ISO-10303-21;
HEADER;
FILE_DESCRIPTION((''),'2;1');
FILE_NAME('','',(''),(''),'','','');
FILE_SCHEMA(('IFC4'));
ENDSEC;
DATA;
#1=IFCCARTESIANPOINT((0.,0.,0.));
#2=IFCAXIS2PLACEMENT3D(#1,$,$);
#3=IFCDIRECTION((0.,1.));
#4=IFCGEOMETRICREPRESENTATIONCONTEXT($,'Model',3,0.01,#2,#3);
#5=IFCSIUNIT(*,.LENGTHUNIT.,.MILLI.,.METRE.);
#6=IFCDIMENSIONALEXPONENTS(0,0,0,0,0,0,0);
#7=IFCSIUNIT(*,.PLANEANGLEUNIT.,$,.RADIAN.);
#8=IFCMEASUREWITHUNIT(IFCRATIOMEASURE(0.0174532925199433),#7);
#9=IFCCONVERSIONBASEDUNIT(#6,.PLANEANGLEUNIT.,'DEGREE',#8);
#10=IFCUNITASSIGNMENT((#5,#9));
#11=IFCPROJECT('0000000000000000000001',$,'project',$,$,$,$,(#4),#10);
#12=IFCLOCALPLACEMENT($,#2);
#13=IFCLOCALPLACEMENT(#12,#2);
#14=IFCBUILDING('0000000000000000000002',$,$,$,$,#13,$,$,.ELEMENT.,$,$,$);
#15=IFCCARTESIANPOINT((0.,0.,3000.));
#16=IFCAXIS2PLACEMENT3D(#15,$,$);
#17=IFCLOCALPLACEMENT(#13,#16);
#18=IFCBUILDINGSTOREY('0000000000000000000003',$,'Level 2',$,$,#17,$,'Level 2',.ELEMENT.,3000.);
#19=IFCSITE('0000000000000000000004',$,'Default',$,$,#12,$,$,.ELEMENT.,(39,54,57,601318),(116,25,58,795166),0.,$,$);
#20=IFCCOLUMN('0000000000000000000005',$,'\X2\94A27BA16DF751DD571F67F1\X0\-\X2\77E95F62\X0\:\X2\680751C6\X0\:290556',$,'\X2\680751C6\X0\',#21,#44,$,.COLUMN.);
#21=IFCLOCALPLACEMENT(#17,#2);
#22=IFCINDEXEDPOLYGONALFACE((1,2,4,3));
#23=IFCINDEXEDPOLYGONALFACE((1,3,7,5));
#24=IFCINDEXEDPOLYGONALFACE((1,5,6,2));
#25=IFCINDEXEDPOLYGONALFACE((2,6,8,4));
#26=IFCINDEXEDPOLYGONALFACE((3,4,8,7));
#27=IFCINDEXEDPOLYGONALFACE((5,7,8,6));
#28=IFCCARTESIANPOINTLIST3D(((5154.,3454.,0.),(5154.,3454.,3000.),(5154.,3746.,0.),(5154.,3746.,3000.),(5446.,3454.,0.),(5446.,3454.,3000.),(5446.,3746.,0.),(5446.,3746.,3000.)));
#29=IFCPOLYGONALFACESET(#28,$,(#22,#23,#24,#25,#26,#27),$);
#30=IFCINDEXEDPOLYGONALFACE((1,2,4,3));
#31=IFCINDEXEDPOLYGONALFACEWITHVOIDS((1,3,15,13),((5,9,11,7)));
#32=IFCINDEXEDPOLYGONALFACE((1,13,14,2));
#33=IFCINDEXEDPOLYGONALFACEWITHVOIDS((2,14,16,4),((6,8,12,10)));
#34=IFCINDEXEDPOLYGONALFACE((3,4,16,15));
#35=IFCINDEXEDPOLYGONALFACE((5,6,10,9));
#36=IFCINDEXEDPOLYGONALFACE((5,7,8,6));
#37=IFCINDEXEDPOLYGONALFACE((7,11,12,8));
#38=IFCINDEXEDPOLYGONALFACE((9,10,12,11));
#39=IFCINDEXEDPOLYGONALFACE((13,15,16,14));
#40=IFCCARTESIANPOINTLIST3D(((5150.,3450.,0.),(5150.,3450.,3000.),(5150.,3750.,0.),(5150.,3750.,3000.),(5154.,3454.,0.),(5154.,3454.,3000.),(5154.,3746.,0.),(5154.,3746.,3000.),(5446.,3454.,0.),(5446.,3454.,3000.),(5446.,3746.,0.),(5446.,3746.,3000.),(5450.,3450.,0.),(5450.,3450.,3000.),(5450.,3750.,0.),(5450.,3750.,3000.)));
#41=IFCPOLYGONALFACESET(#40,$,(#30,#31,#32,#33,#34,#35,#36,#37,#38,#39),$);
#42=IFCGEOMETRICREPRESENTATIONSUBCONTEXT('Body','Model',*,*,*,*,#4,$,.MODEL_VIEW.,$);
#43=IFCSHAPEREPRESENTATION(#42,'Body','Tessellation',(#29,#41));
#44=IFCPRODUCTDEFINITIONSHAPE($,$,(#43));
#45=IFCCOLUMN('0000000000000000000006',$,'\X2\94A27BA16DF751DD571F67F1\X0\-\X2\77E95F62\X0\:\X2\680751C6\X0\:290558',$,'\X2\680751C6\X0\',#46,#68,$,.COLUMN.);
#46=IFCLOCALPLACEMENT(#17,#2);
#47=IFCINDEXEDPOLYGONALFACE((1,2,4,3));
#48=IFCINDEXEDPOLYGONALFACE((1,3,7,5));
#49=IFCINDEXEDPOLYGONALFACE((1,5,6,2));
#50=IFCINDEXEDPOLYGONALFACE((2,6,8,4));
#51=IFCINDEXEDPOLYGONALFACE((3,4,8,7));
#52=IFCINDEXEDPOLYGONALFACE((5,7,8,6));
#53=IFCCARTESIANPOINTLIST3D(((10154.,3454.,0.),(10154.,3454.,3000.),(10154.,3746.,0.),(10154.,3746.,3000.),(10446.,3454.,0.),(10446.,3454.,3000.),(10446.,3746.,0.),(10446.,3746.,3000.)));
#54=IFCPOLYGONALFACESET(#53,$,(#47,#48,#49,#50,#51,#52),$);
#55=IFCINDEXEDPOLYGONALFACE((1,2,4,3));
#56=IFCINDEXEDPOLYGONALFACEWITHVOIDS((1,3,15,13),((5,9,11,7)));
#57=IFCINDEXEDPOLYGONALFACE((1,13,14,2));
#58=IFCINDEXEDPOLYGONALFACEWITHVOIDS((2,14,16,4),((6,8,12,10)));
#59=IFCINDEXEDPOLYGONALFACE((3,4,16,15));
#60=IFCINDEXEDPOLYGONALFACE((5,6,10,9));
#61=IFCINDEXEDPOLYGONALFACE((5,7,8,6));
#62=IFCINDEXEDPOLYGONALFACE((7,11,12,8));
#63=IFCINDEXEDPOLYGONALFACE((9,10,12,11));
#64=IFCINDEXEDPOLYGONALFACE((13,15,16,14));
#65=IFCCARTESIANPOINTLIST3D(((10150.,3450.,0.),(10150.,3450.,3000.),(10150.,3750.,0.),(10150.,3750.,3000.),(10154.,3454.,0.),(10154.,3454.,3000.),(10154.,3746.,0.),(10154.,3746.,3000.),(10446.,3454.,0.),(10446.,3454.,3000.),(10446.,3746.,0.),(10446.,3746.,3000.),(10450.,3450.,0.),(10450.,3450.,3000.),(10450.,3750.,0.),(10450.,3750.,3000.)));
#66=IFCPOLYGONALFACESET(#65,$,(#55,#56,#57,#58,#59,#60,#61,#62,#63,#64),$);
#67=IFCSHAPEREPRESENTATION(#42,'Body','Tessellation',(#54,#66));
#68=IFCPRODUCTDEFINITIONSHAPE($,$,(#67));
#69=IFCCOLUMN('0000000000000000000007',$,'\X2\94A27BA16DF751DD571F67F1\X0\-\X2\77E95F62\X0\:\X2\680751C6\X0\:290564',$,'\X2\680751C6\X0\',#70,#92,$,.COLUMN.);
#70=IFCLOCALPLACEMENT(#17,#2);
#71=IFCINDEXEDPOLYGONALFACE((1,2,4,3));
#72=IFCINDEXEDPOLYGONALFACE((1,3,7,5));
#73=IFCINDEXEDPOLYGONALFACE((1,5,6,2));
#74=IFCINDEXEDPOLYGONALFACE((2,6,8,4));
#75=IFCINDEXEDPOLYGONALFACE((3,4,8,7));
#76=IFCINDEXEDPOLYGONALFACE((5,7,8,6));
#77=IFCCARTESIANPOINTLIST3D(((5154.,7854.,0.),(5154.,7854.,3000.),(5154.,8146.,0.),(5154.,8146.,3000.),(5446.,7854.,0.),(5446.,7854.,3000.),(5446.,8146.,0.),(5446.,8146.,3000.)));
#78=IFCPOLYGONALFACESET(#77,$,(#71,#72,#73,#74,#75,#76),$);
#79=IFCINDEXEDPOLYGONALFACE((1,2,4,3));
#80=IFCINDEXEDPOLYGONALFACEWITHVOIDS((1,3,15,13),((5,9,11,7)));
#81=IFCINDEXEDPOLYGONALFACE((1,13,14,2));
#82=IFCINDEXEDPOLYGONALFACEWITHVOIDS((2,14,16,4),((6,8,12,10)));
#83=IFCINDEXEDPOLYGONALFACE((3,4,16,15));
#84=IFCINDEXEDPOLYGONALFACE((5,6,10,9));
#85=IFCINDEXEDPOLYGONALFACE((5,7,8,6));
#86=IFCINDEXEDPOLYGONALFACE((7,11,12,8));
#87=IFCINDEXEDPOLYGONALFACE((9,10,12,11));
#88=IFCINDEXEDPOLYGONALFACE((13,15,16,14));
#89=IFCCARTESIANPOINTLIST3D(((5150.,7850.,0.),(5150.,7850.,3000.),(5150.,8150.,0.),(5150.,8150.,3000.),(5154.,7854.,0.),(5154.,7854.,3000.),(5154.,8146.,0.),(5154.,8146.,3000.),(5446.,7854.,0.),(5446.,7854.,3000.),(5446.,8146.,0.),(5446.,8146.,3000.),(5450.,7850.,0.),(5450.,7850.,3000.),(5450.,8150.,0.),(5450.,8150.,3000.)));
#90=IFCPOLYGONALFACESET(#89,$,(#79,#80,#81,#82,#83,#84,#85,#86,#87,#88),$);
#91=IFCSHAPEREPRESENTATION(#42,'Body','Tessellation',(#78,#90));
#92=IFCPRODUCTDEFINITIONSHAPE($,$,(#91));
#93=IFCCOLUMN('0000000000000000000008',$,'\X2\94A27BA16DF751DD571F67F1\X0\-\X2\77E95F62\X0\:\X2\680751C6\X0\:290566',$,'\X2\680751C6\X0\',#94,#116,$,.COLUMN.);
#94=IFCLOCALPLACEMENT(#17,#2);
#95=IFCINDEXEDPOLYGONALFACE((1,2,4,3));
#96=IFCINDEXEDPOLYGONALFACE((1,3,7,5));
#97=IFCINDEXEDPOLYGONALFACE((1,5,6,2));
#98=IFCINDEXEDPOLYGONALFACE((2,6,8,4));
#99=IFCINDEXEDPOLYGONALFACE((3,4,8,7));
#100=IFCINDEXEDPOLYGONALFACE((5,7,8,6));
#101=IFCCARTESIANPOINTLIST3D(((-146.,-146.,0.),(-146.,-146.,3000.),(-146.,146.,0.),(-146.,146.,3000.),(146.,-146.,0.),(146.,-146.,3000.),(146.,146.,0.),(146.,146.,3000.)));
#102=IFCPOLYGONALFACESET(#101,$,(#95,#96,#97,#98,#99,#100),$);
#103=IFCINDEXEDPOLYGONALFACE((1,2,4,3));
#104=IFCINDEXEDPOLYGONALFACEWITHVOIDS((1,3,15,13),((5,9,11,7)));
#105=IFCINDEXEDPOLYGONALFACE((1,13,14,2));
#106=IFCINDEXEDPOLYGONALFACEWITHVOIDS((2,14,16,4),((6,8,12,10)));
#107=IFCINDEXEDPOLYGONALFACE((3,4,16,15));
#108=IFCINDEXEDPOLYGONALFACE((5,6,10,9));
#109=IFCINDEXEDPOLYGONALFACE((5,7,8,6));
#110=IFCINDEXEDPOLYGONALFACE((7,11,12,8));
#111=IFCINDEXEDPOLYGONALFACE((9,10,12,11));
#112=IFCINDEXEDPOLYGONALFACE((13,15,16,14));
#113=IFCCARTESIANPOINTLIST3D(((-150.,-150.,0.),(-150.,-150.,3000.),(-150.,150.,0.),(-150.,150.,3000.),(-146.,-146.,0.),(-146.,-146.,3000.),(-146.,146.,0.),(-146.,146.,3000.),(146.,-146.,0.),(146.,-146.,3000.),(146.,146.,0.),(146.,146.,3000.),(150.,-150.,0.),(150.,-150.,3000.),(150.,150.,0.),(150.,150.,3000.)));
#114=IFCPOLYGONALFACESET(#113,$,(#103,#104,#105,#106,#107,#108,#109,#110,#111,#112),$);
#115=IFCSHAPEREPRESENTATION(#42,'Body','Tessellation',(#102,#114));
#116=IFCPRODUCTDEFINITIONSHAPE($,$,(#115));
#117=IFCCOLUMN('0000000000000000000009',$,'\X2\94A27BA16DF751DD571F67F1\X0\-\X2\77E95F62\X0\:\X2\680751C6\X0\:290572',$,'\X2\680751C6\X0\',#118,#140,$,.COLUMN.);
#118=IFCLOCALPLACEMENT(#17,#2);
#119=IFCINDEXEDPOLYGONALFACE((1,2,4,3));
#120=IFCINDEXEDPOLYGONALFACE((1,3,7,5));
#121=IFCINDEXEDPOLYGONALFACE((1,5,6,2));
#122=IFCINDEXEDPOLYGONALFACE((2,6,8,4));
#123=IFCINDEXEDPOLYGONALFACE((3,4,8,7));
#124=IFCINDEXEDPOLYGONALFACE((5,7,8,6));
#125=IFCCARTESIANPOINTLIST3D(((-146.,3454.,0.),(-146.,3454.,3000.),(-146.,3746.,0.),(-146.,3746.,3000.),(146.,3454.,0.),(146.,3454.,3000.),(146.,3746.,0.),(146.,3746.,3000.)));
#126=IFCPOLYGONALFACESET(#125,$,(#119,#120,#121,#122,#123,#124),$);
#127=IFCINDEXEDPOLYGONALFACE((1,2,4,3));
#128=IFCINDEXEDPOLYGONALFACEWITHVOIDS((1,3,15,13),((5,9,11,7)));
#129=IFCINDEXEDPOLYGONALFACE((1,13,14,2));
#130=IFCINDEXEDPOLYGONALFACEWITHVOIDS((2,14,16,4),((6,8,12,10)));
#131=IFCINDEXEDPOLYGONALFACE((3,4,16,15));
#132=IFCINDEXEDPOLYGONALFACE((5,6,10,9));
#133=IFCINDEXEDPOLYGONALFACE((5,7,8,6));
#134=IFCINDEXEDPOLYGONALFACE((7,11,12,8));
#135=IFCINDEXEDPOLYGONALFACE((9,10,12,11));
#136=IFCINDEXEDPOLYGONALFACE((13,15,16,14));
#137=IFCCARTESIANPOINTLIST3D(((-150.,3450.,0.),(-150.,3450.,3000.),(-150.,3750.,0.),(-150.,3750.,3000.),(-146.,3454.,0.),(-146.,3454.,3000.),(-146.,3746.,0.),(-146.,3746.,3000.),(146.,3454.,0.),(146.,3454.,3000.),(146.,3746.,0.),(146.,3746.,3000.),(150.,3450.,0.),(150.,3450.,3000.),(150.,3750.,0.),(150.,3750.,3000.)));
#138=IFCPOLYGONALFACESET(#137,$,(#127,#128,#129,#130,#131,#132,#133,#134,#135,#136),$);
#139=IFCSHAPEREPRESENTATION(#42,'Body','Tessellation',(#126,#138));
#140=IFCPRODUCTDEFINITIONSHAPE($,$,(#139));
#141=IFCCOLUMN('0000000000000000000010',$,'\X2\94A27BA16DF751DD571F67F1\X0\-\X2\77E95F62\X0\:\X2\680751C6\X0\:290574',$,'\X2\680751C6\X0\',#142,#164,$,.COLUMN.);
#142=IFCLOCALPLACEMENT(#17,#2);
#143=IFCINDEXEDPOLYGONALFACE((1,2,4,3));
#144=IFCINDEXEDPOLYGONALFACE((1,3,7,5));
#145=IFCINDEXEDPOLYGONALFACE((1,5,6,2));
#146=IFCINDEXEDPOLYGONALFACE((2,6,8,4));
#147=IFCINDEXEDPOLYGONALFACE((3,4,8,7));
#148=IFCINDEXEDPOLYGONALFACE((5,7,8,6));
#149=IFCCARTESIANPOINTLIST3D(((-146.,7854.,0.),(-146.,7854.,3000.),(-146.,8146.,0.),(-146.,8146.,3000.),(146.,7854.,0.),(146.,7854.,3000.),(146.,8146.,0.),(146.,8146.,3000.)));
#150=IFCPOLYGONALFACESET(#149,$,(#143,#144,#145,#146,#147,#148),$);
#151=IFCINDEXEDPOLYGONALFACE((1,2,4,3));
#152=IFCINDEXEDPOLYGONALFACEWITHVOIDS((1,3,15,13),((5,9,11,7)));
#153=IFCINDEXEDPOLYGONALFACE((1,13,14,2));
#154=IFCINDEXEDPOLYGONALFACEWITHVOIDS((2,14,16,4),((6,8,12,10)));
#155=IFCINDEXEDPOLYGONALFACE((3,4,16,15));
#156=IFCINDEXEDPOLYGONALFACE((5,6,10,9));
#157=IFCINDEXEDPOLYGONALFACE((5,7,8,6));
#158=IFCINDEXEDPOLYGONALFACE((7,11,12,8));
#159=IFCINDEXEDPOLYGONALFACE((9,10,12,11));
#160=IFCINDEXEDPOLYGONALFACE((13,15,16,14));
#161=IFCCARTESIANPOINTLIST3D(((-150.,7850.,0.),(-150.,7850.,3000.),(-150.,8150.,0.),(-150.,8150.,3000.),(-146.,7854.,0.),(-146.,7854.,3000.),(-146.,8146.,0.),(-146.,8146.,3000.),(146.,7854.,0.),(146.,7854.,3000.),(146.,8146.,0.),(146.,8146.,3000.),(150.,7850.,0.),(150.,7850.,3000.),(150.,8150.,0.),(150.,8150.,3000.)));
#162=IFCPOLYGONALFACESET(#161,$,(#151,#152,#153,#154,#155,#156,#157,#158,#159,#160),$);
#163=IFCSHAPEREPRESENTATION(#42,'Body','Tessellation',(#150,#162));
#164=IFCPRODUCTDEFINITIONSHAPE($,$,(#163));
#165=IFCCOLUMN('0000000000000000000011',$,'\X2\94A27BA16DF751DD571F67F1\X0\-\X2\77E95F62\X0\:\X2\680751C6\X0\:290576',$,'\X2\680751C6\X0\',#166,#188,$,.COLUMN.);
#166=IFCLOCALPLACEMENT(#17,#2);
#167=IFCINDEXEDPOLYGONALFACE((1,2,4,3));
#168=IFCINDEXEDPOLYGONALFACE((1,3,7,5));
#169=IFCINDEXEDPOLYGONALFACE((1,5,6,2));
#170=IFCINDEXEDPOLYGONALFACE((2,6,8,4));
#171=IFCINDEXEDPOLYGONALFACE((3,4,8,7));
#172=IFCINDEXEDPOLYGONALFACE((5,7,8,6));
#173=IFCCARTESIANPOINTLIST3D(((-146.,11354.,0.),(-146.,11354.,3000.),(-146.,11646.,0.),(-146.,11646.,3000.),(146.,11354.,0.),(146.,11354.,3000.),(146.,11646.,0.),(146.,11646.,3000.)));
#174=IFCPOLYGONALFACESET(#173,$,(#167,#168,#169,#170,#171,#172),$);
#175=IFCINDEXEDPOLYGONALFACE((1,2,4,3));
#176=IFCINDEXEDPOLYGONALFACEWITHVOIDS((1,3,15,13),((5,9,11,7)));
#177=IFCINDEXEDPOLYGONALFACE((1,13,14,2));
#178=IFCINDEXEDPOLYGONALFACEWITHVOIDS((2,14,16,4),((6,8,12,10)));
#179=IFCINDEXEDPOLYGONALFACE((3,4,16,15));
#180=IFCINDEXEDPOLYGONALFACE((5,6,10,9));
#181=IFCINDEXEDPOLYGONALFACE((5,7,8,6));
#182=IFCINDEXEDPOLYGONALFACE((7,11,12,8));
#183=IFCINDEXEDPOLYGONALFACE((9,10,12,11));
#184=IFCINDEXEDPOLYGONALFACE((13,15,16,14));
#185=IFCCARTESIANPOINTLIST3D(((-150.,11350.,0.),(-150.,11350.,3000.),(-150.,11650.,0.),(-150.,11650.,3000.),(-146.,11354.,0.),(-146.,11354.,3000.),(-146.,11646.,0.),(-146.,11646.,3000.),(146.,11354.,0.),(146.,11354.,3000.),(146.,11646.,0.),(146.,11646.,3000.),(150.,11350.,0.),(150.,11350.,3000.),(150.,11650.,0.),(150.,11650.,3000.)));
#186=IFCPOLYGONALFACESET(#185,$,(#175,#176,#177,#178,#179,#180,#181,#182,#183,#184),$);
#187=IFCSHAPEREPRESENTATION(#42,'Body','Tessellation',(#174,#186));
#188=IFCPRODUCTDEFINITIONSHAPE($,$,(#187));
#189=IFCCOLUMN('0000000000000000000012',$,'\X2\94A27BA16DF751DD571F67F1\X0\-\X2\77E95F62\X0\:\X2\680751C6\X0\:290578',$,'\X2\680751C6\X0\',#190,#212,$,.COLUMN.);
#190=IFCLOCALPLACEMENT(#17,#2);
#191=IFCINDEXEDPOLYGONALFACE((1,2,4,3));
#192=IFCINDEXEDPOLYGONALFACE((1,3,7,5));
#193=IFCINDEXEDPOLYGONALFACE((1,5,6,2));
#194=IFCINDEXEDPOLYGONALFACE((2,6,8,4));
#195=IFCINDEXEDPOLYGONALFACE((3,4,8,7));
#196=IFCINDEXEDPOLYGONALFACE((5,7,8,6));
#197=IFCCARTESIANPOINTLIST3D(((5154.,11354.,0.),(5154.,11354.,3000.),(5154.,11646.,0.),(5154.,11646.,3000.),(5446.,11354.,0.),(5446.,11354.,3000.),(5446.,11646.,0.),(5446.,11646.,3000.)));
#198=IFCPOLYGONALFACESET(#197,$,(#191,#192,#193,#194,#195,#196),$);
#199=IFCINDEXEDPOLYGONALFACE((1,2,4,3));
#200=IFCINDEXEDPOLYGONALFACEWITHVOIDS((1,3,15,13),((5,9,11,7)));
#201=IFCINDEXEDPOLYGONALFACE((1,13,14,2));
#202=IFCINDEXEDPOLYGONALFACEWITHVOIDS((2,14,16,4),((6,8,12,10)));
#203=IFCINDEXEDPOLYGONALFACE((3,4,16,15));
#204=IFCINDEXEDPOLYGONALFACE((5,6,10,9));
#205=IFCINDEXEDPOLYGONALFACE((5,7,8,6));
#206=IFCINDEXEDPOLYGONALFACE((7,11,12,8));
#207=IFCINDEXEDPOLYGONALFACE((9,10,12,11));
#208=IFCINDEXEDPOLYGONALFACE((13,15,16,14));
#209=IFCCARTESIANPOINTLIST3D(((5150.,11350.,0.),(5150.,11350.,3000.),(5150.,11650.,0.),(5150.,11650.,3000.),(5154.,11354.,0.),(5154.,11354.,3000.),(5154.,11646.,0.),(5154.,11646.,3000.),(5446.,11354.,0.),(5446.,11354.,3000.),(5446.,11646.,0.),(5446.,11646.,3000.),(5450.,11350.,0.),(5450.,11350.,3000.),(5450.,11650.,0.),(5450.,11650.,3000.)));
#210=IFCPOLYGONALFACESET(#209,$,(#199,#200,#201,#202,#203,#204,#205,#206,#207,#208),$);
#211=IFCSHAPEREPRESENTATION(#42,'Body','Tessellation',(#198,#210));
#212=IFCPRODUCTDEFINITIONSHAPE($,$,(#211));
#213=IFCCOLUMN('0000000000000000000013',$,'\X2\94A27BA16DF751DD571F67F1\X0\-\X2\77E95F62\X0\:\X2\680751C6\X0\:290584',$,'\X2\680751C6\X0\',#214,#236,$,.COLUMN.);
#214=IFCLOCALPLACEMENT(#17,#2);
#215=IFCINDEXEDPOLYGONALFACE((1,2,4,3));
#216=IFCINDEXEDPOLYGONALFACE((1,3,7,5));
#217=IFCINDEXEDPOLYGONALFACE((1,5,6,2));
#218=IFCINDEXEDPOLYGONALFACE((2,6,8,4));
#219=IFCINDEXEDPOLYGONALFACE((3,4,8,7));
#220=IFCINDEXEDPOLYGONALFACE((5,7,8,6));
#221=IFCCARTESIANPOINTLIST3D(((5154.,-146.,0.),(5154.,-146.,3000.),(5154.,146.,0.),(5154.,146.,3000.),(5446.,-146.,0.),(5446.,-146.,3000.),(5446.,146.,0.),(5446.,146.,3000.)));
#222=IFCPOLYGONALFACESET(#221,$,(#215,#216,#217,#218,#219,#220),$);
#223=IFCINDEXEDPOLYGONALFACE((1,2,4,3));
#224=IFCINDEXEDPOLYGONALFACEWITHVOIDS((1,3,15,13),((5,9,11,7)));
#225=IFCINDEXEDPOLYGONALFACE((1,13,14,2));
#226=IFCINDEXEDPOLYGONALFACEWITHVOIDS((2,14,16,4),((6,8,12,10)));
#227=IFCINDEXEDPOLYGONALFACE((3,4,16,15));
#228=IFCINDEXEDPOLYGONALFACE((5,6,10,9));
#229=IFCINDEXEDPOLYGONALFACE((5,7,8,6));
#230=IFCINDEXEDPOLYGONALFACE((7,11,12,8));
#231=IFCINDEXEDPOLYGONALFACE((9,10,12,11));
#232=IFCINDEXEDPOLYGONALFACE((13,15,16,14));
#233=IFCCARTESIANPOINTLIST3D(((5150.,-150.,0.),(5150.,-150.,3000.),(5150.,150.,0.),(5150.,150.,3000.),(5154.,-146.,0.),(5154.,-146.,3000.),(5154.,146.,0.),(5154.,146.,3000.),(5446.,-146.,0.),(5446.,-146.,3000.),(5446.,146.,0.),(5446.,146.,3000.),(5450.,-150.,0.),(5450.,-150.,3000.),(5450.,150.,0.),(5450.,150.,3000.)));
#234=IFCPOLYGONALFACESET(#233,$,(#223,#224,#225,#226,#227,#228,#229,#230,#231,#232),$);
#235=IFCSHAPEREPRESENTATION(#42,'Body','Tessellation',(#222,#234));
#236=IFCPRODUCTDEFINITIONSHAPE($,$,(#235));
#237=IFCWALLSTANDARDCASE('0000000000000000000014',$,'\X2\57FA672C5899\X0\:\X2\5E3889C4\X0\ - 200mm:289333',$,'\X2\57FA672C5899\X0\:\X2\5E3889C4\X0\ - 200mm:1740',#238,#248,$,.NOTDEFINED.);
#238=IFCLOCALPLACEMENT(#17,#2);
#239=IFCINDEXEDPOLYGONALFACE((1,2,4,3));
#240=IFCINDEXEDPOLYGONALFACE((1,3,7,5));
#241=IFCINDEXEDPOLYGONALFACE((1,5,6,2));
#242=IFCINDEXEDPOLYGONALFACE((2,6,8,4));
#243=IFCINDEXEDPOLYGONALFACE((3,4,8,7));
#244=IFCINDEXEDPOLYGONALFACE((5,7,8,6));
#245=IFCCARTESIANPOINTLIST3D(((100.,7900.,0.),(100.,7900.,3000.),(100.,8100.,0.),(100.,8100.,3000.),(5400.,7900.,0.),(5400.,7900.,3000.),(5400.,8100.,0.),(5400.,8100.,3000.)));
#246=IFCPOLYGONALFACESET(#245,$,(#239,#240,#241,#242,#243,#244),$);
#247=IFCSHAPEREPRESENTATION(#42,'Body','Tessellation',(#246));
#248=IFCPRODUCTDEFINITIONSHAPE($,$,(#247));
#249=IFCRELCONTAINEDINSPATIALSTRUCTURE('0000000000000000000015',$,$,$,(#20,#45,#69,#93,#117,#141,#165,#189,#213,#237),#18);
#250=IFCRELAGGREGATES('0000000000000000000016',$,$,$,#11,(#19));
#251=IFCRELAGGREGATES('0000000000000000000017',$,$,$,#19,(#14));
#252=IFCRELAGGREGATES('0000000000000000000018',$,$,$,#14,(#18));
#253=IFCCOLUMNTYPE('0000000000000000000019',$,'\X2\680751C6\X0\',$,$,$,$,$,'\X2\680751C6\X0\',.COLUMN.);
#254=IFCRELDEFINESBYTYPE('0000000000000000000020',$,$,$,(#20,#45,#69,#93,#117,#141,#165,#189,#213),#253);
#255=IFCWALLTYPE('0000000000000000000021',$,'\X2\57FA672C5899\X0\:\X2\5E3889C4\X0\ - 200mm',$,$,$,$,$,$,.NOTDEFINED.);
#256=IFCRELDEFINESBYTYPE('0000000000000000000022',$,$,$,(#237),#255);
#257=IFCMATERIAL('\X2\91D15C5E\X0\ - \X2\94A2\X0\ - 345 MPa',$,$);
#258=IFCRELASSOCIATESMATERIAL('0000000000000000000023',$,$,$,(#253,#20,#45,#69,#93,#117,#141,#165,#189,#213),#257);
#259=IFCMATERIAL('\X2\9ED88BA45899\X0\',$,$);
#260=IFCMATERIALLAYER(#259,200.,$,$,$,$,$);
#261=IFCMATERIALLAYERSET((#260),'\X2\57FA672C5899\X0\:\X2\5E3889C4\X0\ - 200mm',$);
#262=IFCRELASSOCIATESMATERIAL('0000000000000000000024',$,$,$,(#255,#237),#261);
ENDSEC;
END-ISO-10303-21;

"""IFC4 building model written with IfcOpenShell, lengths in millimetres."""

from ifc_helpers import new_model, entity, si_unit, converted_unit, direction, frame, frame_2d, origin, origin_2d_with_axis, place, context, subcontext, project, spatial, polyline, rectangle, outline, extrude, source, transform, mapped, material, layer, layer_set, layer_usage, type_object, type_shapes, element, save


model = new_model("IFC4")

# Units and contexts
model_context = context("Model", 3, precision=0.01, world=origin(), true_north=direction((0.0, 1.0)))
body_context = subcontext(model_context, "Body", "Model", "MODEL_VIEW")
ifc_project = project(units=[si_unit("LENGTHUNIT", "METRE", prefix="MILLI"), converted_unit("PLANEANGLEUNIT", "DEGREE", entity("IfcRatioMeasure", 0.0174532925199433), si_unit("PLANEANGLEUNIT", "RADIAN"), dimensions=[0, 0, 0, 0, 0, 0, 0])], contexts=[model_context])

# Site, building, storey
site_placement = place(None, origin())
site = spatial("IfcSite", under=ifc_project, at=site_placement, Name="Default", CompositionType="ELEMENT", RefLatitude=(39, 54, 57, 601318), RefLongitude=(116, 25, 58, 795166), RefElevation=0.0)
building_placement = place(site_placement, origin())
building = spatial("IfcBuilding", under=site, at=building_placement, CompositionType="ELEMENT")
storey_placement = place(building_placement, frame((0.0, 0.0, 3000.0)))
storey = spatial("IfcBuildingStorey", under=building, at=storey_placement, Name="Level 2", LongName="Level 2", CompositionType="ELEMENT", Elevation=3000.0)

# Columns
ifc_material_1 = material(Name="金属 - 钢 - 345 MPa")
column_type = type_object("IfcColumnType", Name="标准", ElementType="标准", PredefinedType="COLUMN", material=ifc_material_1)
shared_shape_1 = source(origin(), body_context, "Body", "SweptSolid", [
    extrude(rectangle(XDim=292.0, YDim=292.0, at=origin_2d_with_axis()), frame((150.0, 150.0, 0.0), z_axis=(0.0, 0.0, 1.0), x_axis=(-1.0, 0.0, 0.0)), (0.0, 0.0, 1.0), 3000.0),
    extrude(outline(polyline([(-150.0, -150.0), (150.0, -150.0), (150.0, 150.0), (-150.0, 150.0), (-150.0, -150.0)]), holes=[polyline([(-146.0, -146.0), (-146.0, 146.0), (146.0, 146.0), (146.0, -146.0), (-146.0, -146.0)])]), frame((150.0, 150.0, 0.0), z_axis=(0.0, 0.0, 1.0), x_axis=(-1.0, 0.0, 0.0)), (0.0, 0.0, 1.0), 3000.0),
])
type_shapes(column_type, [shared_shape_1])
for number, where, name in (
    (1, (5150.0, 3450.0, 0.0), "钢管混凝土柱-矩形:标准:290556"),
    (2, (10150.0, 3450.0, 0.0), "钢管混凝土柱-矩形:标准:290558"),
    (3, (5150.0, 7850.0, 0.0), "钢管混凝土柱-矩形:标准:290564"),
    (4, (-150.0, -150.0, 0.0), "钢管混凝土柱-矩形:标准:290566"),
    (5, (-150.0, 3450.0, 0.0), "钢管混凝土柱-矩形:标准:290572"),
    (6, (-150.0, 7850.0, 0.0), "钢管混凝土柱-矩形:标准:290574"),
    (7, (-150.0, 11350.0, 0.0), "钢管混凝土柱-矩形:标准:290576"),
    (8, (5150.0, 11350.0, 0.0), "钢管混凝土柱-矩形:标准:290578"),
    (9, (5150.0, -150.0, 0.0), "钢管混凝土柱-矩形:标准:290584"),
):
    element("IfcColumn", number, at=place(storey_placement, frame(where)), inside=storey, type_object=column_type, material=ifc_material_1, Name=name, ObjectType="标准", PredefinedType="COLUMN", context=body_context, shape_type="MappedRepresentation", body=[
        mapped(shared_shape_1, transform((0.0, 0.0, 0.0), scale=1.0)),
    ])

# Wall
ifc_material_2 = material(Name="默认墙")
ifc_layer_1 = layer(ifc_material_2, 200.0)
ifc_layer_set_1 = layer_set([ifc_layer_1], Name="基本墙:常规 - 200mm")
ifc_layer_usage_1 = layer_usage(ifc_layer_set_1, "AXIS2", "NEGATIVE", 100.0)
wall_type = type_object("IfcWallType", Name="基本墙:常规 - 200mm", PredefinedType="NOTDEFINED", material=ifc_layer_set_1)
wall_1_placement = place(storey_placement, frame((100.0, 8000.0, 0.0)))
element("IfcWallStandardCase", 10, at=wall_1_placement, inside=storey, type_object=wall_type, material=ifc_layer_usage_1, Name="基本墙:常规 - 200mm:289333", ObjectType="基本墙:常规 - 200mm:1740", PredefinedType="NOTDEFINED", context=body_context, shape_type="SweptSolid", body=[
    extrude(rectangle(XDim=5300.0, YDim=200.0, at=frame_2d((2650.0, 0.0), x_axis=(-1.0, 0.0))), origin(), (0.0, 0.0, 1.0), 3000.0),
])

save(model, "model.ifc")
